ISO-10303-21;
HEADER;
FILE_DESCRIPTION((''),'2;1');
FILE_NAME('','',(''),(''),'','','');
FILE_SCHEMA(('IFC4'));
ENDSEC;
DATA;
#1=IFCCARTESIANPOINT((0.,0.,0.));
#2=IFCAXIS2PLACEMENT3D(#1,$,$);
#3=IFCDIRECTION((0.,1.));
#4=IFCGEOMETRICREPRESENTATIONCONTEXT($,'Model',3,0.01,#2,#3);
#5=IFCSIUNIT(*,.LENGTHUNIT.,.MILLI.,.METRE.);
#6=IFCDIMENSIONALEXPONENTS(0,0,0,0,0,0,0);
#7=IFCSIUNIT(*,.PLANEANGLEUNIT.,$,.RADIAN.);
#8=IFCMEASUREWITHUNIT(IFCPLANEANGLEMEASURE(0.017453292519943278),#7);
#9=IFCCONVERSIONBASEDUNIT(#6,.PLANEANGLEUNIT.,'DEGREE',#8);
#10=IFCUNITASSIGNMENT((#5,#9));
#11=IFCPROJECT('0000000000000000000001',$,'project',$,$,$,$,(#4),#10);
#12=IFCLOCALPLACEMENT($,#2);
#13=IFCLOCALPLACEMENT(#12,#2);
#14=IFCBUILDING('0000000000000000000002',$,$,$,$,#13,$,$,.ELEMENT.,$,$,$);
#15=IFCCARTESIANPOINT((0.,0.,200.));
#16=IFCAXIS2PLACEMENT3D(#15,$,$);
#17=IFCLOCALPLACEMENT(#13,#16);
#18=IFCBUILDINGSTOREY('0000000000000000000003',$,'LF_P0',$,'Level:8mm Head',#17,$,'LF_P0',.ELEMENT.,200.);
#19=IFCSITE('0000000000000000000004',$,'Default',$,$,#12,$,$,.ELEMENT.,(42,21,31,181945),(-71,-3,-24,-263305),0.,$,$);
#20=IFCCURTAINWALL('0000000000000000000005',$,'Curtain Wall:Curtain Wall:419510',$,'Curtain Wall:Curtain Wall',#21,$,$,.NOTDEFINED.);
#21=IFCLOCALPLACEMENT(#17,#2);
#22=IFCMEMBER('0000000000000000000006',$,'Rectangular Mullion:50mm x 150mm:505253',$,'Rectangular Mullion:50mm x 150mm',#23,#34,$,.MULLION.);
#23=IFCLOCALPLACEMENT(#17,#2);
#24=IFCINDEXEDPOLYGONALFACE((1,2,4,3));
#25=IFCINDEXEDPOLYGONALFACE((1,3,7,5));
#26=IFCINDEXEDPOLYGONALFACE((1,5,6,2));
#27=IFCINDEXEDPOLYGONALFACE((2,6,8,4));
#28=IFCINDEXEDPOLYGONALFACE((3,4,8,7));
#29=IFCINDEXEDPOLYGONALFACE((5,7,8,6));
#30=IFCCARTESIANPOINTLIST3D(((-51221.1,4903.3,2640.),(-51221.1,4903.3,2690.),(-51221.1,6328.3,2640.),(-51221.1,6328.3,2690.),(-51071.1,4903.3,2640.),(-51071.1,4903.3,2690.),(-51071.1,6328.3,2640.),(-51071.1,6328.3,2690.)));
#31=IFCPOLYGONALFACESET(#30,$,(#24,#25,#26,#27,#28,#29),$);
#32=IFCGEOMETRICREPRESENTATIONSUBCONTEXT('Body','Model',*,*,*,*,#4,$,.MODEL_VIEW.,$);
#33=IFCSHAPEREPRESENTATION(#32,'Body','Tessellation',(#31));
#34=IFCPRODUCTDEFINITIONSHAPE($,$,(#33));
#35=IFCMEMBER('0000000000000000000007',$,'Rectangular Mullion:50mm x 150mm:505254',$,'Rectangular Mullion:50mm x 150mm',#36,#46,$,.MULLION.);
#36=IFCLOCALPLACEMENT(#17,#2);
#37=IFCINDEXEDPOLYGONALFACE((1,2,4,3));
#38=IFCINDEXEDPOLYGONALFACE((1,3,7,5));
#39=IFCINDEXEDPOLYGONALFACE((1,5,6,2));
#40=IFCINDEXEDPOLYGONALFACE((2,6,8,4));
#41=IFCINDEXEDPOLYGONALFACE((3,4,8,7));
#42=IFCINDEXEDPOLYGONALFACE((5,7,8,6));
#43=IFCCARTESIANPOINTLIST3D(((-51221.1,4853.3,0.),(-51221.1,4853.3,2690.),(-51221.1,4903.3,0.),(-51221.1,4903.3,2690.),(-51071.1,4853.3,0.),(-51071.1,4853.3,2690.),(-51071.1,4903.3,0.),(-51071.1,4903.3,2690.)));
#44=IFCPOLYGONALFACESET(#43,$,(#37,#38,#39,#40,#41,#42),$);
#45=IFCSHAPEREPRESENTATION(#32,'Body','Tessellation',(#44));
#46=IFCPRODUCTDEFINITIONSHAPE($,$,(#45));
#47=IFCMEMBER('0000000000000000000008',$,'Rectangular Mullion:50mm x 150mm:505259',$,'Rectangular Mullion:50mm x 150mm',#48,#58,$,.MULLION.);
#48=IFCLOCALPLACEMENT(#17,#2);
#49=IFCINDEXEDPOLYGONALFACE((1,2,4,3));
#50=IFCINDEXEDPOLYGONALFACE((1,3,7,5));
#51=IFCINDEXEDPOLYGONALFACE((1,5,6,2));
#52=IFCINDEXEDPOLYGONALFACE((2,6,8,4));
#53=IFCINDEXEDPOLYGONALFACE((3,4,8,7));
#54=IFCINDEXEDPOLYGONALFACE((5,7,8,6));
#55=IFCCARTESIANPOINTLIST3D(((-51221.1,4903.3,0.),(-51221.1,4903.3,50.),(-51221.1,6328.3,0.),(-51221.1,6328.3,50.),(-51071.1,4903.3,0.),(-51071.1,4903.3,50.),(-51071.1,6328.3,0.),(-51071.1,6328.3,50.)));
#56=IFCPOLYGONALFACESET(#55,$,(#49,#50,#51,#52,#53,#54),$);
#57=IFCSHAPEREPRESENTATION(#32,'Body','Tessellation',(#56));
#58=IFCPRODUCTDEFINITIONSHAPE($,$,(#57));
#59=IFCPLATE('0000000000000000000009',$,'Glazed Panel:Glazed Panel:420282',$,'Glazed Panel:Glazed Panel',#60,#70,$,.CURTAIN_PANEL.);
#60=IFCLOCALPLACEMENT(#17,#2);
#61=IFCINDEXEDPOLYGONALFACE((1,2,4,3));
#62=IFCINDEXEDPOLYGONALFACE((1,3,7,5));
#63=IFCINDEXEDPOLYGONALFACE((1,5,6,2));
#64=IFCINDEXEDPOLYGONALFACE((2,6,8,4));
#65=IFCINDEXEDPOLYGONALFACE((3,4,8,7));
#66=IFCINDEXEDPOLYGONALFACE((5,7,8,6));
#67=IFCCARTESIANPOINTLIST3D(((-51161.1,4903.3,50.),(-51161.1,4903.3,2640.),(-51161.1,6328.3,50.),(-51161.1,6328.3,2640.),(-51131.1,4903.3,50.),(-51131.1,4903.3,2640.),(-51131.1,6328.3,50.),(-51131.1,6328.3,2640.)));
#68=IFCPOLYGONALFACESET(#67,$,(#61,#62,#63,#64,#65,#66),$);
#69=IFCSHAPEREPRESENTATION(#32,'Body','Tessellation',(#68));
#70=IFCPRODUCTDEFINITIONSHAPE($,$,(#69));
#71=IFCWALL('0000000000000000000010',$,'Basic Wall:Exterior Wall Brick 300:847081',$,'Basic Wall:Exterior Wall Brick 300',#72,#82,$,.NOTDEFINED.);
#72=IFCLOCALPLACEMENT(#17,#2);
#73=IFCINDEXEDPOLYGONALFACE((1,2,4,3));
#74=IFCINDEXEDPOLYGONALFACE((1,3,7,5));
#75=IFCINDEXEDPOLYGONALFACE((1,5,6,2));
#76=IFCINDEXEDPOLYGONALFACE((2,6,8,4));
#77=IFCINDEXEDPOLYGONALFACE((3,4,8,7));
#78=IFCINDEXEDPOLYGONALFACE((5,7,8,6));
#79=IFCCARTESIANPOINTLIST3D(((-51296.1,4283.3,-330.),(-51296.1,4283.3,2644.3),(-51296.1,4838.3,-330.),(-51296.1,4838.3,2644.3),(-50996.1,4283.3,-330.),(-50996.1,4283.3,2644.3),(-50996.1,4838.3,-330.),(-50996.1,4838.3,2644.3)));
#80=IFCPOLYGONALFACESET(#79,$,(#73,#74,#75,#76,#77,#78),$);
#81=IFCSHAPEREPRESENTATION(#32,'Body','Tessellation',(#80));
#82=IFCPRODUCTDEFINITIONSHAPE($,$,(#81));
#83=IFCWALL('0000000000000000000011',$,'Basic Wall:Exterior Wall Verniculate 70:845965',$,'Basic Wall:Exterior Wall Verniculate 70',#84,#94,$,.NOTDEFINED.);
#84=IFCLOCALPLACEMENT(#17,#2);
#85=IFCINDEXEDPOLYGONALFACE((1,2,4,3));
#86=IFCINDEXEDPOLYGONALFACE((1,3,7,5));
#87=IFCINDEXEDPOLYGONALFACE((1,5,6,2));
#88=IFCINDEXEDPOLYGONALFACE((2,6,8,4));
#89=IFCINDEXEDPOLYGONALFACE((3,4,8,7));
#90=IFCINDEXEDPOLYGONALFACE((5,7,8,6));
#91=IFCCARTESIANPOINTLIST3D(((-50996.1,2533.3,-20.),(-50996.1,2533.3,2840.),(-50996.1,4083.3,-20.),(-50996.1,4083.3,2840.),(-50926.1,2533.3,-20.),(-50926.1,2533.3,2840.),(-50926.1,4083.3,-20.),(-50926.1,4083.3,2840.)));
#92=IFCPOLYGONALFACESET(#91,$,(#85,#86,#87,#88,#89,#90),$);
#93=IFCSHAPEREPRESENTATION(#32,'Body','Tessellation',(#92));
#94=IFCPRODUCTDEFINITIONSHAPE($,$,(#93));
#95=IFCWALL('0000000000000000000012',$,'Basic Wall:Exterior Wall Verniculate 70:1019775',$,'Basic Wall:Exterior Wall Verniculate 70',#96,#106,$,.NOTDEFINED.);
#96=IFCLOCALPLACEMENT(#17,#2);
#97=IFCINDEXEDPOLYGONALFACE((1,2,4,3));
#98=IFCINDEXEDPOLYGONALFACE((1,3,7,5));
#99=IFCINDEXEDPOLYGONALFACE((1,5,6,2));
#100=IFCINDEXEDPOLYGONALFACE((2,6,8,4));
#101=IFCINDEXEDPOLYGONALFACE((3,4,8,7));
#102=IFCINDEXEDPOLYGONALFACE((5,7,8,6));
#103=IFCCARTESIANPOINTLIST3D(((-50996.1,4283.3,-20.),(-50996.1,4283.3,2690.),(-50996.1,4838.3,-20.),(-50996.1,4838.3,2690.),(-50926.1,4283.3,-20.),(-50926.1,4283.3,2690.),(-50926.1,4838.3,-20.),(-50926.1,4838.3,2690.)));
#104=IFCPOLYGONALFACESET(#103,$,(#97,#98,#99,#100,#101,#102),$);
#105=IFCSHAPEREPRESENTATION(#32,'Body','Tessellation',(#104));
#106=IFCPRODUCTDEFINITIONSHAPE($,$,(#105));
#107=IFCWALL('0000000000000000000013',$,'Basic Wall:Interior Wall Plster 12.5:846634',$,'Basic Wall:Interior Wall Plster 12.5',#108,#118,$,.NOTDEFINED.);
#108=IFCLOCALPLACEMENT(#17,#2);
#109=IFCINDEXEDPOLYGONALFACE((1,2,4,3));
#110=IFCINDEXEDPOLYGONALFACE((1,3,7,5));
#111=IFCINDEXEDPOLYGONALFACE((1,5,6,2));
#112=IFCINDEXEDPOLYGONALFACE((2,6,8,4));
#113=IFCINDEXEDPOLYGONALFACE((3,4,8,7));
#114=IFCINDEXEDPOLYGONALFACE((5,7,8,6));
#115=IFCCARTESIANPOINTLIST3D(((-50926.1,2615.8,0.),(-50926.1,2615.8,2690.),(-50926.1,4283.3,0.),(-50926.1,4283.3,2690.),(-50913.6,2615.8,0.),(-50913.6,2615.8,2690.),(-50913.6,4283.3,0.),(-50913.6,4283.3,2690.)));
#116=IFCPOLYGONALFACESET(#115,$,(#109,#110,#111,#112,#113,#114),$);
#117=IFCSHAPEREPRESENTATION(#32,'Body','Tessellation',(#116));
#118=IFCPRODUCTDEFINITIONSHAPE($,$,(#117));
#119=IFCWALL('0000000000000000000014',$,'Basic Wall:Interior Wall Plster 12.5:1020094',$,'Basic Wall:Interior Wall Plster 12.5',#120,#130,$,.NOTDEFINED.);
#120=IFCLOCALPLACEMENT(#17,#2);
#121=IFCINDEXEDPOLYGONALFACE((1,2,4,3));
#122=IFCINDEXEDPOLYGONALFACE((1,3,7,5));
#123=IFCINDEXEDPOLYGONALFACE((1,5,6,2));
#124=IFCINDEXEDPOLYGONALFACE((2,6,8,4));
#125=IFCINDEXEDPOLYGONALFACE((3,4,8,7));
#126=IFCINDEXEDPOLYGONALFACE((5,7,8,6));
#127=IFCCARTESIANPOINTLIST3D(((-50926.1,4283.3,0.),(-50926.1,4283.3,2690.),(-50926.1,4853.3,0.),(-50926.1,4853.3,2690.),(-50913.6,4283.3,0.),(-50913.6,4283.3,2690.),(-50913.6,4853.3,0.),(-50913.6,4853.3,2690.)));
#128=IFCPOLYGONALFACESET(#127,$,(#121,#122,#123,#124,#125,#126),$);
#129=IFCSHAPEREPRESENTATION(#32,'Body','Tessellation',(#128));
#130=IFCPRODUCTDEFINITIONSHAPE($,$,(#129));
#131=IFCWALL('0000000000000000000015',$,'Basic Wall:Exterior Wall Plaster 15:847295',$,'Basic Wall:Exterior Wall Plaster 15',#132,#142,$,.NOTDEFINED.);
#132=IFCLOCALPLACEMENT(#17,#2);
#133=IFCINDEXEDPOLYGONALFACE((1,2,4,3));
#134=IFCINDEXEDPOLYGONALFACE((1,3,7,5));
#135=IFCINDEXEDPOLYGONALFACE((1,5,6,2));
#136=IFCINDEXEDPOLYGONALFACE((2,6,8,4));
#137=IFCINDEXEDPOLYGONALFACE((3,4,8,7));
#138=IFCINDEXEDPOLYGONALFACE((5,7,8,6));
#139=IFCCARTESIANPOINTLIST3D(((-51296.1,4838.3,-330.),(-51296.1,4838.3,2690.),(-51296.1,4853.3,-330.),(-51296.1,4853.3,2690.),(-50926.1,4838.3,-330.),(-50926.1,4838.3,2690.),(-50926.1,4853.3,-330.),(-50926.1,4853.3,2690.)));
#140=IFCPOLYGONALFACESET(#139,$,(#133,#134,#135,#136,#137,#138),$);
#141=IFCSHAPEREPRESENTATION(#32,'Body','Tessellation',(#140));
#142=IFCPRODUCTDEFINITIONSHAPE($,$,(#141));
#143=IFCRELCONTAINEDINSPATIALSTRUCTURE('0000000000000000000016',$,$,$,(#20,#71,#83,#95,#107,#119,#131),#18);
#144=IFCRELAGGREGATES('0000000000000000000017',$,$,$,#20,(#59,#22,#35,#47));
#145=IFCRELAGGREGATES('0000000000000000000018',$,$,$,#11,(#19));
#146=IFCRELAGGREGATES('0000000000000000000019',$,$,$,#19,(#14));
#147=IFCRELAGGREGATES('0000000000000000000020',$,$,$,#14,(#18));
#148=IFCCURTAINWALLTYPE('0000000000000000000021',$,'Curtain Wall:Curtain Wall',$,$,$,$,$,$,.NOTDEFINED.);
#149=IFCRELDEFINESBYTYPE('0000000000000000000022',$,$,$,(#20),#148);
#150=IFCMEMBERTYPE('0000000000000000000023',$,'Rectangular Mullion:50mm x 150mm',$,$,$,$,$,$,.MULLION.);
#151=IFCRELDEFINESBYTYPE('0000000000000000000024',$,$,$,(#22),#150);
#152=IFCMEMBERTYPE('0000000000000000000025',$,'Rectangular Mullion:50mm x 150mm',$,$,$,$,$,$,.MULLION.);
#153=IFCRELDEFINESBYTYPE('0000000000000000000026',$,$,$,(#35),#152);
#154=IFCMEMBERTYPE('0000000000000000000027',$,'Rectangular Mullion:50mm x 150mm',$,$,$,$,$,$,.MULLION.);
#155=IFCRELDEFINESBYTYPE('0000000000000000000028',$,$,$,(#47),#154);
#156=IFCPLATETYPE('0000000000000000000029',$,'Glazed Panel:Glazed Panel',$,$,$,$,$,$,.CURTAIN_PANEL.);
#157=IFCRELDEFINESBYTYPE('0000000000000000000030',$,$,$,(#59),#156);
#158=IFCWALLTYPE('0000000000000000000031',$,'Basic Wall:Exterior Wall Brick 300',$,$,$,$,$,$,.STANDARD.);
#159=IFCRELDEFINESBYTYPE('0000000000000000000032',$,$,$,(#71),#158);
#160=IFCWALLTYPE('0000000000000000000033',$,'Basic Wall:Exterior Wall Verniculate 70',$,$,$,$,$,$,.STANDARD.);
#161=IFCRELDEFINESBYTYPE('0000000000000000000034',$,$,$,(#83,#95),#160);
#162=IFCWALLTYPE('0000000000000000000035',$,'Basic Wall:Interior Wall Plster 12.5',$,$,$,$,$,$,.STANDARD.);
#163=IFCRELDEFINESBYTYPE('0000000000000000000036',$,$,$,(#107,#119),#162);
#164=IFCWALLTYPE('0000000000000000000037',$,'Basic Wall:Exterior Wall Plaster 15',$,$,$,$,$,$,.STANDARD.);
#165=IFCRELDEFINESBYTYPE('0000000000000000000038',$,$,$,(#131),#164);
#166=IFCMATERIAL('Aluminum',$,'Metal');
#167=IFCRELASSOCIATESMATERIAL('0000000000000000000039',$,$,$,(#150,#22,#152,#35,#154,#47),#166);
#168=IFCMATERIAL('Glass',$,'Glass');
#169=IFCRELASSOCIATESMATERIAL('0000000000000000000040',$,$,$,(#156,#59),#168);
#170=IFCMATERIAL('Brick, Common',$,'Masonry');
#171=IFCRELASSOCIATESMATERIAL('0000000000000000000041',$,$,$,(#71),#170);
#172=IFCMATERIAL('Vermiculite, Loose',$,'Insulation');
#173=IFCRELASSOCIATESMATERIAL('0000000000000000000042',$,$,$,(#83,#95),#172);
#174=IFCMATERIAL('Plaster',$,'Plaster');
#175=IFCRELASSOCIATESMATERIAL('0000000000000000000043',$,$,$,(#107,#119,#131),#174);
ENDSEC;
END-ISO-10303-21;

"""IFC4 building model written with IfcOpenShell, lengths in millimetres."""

from ifc_helpers import new_model, entity, si_unit, converted_unit, direction, frame, origin, place, context, subcontext, project, spatial, indexed_curve, outline, extrude, source, transform, mapped, material, type_object, type_shapes, element, aggregate, save


model = new_model("IFC4")

# Units and contexts
model_context = context("Model", 3, precision=0.01, world=origin(), true_north=direction((0.0, 1.0)))
body_context = subcontext(model_context, "Body", "Model", "MODEL_VIEW")
ifc_project = project(units=[si_unit("LENGTHUNIT", "METRE", prefix="MILLI"), converted_unit("PLANEANGLEUNIT", "DEGREE", entity("IfcPlaneAngleMeasure", 0.017453292519943278), si_unit("PLANEANGLEUNIT", "RADIAN"), dimensions=[0, 0, 0, 0, 0, 0, 0])], contexts=[model_context])

# Site, building, storey
site_placement = place(None, origin())
site = spatial("IfcSite", under=ifc_project, at=site_placement, Name="Default", CompositionType="ELEMENT", RefLatitude=(42, 21, 31, 181945), RefLongitude=(-71, -3, -24, -263305), RefElevation=0.0)
building_placement = place(site_placement, origin())
building = spatial("IfcBuilding", under=site, at=building_placement, CompositionType="ELEMENT")
storey_placement = place(building_placement, frame((0.0, 0.0, 200.0)))
storey = spatial("IfcBuildingStorey", under=building, at=storey_placement, Name="LF_P0", ObjectType="Level:8mm Head", LongName="LF_P0", CompositionType="ELEMENT", Elevation=200.0)

# Curtain wall, members, plate
curtain_wall_type = type_object("IfcCurtainWallType", Name="Curtain Wall:Curtain Wall", PredefinedType="NOTDEFINED")
curtain_wall_placement = place(storey_placement, frame((0.0, 0.0, -200.0)))
curtain_wall = element("IfcCurtainWall", 1, at=curtain_wall_placement, inside=storey, type_object=curtain_wall_type, Name="Curtain Wall:Curtain Wall:419510", ObjectType="Curtain Wall:Curtain Wall", PredefinedType="NOTDEFINED")
ifc_material_1 = material(Name="Aluminum", Category="Metal")
member_type_1 = type_object("IfcMemberType", Name="Rectangular Mullion:50mm x 150mm", PredefinedType="MULLION", material=ifc_material_1)
shared_shape_1 = source(origin(), body_context, "Body", "SweptSolid", [
    extrude(outline(indexed_curve([(-25.0, -75.0), (25.0, -75.0), (25.0, 75.0), (-25.0, 75.0), (-25.0, -75.0)], self_intersect=False)), frame((-25.0, 0.0, -1425.0), z_axis=(0.0, 0.0, 1.0), x_axis=(-1.0, 0.0, 0.0)), (0.0, 0.0, 1.0), 1425.0),
])
type_shapes(member_type_1, [shared_shape_1])
member_1_placement = place(curtain_wall_placement, frame((-51146.1, 4903.3, 2890.0), z_axis=(0.0, -1.0, 0.0), x_axis=(0.0, 0.0, 1.0)))
member_1 = element("IfcMember", 2, at=member_1_placement, type_object=member_type_1, material=ifc_material_1, Name="Rectangular Mullion:50mm x 150mm:505253", ObjectType="Rectangular Mullion:50mm x 150mm", PredefinedType="MULLION", context=body_context, shape_type="MappedRepresentation", body=[
    mapped(shared_shape_1, transform((0.0, 0.0, 0.0), scale=1.0)),
])
member_type_2 = type_object("IfcMemberType", Name="Rectangular Mullion:50mm x 150mm", PredefinedType="MULLION", material=ifc_material_1)
shared_shape_2 = source(origin(), body_context, "Body", "SweptSolid", [
    extrude(outline(indexed_curve([(-25.0, -75.0), (25.0, -75.0), (25.0, 75.0), (-25.0, 75.0), (-25.0, -75.0)], self_intersect=False)), frame((-25.0, 0.0, -2690.0), z_axis=(0.0, 0.0, 1.0), x_axis=(-1.0, 0.0, 0.0)), (0.0, 0.0, 1.0), 2690.0),
])
type_shapes(member_type_2, [shared_shape_2])
member_2_placement = place(curtain_wall_placement, frame((-51146.1, 4853.3, 200.0), z_axis=(0.0, 0.0, -1.0), x_axis=(0.0, -1.0, 0.0)))
member_2 = element("IfcMember", 3, at=member_2_placement, type_object=member_type_2, material=ifc_material_1, Name="Rectangular Mullion:50mm x 150mm:505254", ObjectType="Rectangular Mullion:50mm x 150mm", PredefinedType="MULLION", context=body_context, shape_type="MappedRepresentation", body=[
    mapped(shared_shape_2, transform((0.0, 0.0, 0.0), scale=1.0)),
])
member_type_3 = type_object("IfcMemberType", Name="Rectangular Mullion:50mm x 150mm", PredefinedType="MULLION", material=ifc_material_1)
shared_shape_3 = source(origin(), body_context, "Body", "SweptSolid", [
    extrude(outline(indexed_curve([(-25.0, -75.0), (25.0, -75.0), (25.0, 75.0), (-25.0, 75.0), (-25.0, -75.0)], self_intersect=False)), frame((-25.0, 0.0, -1425.0), z_axis=(0.0, 0.0, 1.0), x_axis=(-1.0, 0.0, 0.0)), (0.0, 0.0, 1.0), 1425.0),
])
type_shapes(member_type_3, [shared_shape_3])
member_3_placement = place(curtain_wall_placement, frame((-51146.1, 6328.3, 200.0), z_axis=(0.0, 1.0, 0.0), x_axis=(0.0, 0.0, -1.0)))
member_3 = element("IfcMember", 4, at=member_3_placement, type_object=member_type_3, material=ifc_material_1, Name="Rectangular Mullion:50mm x 150mm:505259", ObjectType="Rectangular Mullion:50mm x 150mm", PredefinedType="MULLION", context=body_context, shape_type="MappedRepresentation", body=[
    mapped(shared_shape_3, transform((0.0, 0.0, 0.0), scale=1.0)),
])
ifc_material_2 = material(Name="Glass", Category="Glass")
plate_type = type_object("IfcPlateType", Name="Glazed Panel:Glazed Panel", PredefinedType="CURTAIN_PANEL", material=ifc_material_2)
shared_shape_4 = source(origin(), body_context, "Body", "SweptSolid", [
    extrude(outline(indexed_curve([(-712.5, -15.0), (712.5, -15.0), (712.5, 15.0), (-712.5, 15.0), (-712.5, -15.0)], self_intersect=False)), frame((0.0, 0.0, 0.0), z_axis=(0.0, 0.0, 1.0), x_axis=(-1.0, 0.0, 0.0)), (0.0, 0.0, 1.0), 2590.0),
])
type_shapes(plate_type, [shared_shape_4])
plate_placement = place(curtain_wall_placement, frame((-51146.1, 5615.8, 250.0), z_axis=(0.0, 0.0, 1.0), x_axis=(0.0, -1.0, 0.0)))
plate = element("IfcPlate", 5, at=plate_placement, type_object=plate_type, material=ifc_material_2, Name="Glazed Panel:Glazed Panel:420282", ObjectType="Glazed Panel:Glazed Panel", PredefinedType="CURTAIN_PANEL", context=body_context, shape_type="MappedRepresentation", body=[
    mapped(shared_shape_4, transform((0.0, 0.0, 0.0), scale=1.0)),
])
aggregate(curtain_wall, [plate, member_1, member_2, member_3])

# Walls
ifc_material_3 = material(Name="Brick, Common", Category="Masonry")
wall_type_1 = type_object("IfcWallType", Name="Basic Wall:Exterior Wall Brick 300", PredefinedType="STANDARD")
wall_1_placement = place(storey_placement, frame((-51146.1, 4283.3, -330.0), z_axis=(0.0, 0.0, 1.0), x_axis=(0.0, 1.0, 0.0)))
element("IfcWall", 6, at=wall_1_placement, inside=storey, type_object=wall_type_1, material=ifc_material_3, Name="Basic Wall:Exterior Wall Brick 300:847081", ObjectType="Basic Wall:Exterior Wall Brick 300", PredefinedType="NOTDEFINED", context=body_context, shape_type="SweptSolid", body=[
    extrude(outline(indexed_curve([(555.0, 150.0), (0.0, 150.0), (0.0, -150.0), (555.0, -150.0), (555.0, 150.0)], self_intersect=False)), origin(), (0.0, 0.0, 1.0), 2974.3),
])
ifc_material_4 = material(Name="Vermiculite, Loose", Category="Insulation")
wall_type_2 = type_object("IfcWallType", Name="Basic Wall:Exterior Wall Verniculate 70", PredefinedType="STANDARD")
wall_2_placement = place(storey_placement, frame((-50961.1, 2533.3, -20.0), z_axis=(0.0, 0.0, 1.0), x_axis=(0.0, 1.0, 0.0)))
element("IfcWall", 7, at=wall_2_placement, inside=storey, type_object=wall_type_2, material=ifc_material_4, Name="Basic Wall:Exterior Wall Verniculate 70:845965", ObjectType="Basic Wall:Exterior Wall Verniculate 70", PredefinedType="NOTDEFINED", context=body_context, shape_type="SweptSolid", body=[
    extrude(outline(indexed_curve([(1550.0, 35.0), (0.0, 35.0), (0.0, -35.0), (1550.0, -35.0), (1550.0, 35.0)], self_intersect=False)), origin(), (0.0, 0.0, 1.0), 2860.0),
])
wall_3_placement = place(storey_placement, frame((-50961.1, 4283.3, -20.0), z_axis=(0.0, 0.0, 1.0), x_axis=(0.0, 1.0, 0.0)))
element("IfcWall", 8, at=wall_3_placement, inside=storey, type_object=wall_type_2, material=ifc_material_4, Name="Basic Wall:Exterior Wall Verniculate 70:1019775", ObjectType="Basic Wall:Exterior Wall Verniculate 70", PredefinedType="NOTDEFINED", context=body_context, shape_type="SweptSolid", body=[
    extrude(outline(indexed_curve([(555.0, 35.0), (0.0, 35.0), (0.0, -35.0), (555.0, -35.0), (555.0, 35.0)], self_intersect=False)), origin(), (0.0, 0.0, 1.0), 2710.0),
])
ifc_material_5 = material(Name="Plaster", Category="Plaster")
wall_type_3 = type_object("IfcWallType", Name="Basic Wall:Interior Wall Plster 12.5", PredefinedType="STANDARD")
wall_4_placement = place(storey_placement, frame((-50919.9, 2615.8, 0.0), z_axis=(0.0, 0.0, 1.0), x_axis=(0.0, 1.0, 0.0)))
element("IfcWall", 9, at=wall_4_placement, inside=storey, type_object=wall_type_3, material=ifc_material_5, Name="Basic Wall:Interior Wall Plster 12.5:846634", ObjectType="Basic Wall:Interior Wall Plster 12.5", PredefinedType="NOTDEFINED", context=body_context, shape_type="SweptSolid", body=[
    extrude(outline(indexed_curve([(1667.5, 6.3), (0.0, 6.3), (0.0, -6.3), (1667.5, -6.3), (1667.5, 6.3)], self_intersect=False)), origin(), (0.0, 0.0, 1.0), 2690.0),
])
wall_5_placement = place(storey_placement, frame((-50919.9, 4283.3, 0.0), z_axis=(0.0, 0.0, 1.0), x_axis=(0.0, 1.0, 0.0)))
element("IfcWall", 10, at=wall_5_placement, inside=storey, type_object=wall_type_3, material=ifc_material_5, Name="Basic Wall:Interior Wall Plster 12.5:1020094", ObjectType="Basic Wall:Interior Wall Plster 12.5", PredefinedType="NOTDEFINED", context=body_context, shape_type="SweptSolid", body=[
    extrude(outline(indexed_curve([(570.0, 6.3), (0.0, 6.3), (0.0, -6.3), (570.0, -6.3), (570.0, 6.3)], self_intersect=False)), origin(), (0.0, 0.0, 1.0), 2690.0),
])
wall_type_4 = type_object("IfcWallType", Name="Basic Wall:Exterior Wall Plaster 15", PredefinedType="STANDARD")
wall_6_placement = place(storey_placement, frame((-51296.1, 4845.8, -330.0)))
element("IfcWall", 11, at=wall_6_placement, inside=storey, type_object=wall_type_4, material=ifc_material_5, Name="Basic Wall:Exterior Wall Plaster 15:847295", ObjectType="Basic Wall:Exterior Wall Plaster 15", PredefinedType="NOTDEFINED", context=body_context, shape_type="SweptSolid", body=[
    extrude(outline(indexed_curve([(370.0, 7.5), (0.0, 7.5), (0.0, -7.5), (370.0, -7.5), (370.0, 7.5)], self_intersect=False)), origin(), (0.0, 0.0, 1.0), 3020.0),
])

save(model, "model.ifc")
